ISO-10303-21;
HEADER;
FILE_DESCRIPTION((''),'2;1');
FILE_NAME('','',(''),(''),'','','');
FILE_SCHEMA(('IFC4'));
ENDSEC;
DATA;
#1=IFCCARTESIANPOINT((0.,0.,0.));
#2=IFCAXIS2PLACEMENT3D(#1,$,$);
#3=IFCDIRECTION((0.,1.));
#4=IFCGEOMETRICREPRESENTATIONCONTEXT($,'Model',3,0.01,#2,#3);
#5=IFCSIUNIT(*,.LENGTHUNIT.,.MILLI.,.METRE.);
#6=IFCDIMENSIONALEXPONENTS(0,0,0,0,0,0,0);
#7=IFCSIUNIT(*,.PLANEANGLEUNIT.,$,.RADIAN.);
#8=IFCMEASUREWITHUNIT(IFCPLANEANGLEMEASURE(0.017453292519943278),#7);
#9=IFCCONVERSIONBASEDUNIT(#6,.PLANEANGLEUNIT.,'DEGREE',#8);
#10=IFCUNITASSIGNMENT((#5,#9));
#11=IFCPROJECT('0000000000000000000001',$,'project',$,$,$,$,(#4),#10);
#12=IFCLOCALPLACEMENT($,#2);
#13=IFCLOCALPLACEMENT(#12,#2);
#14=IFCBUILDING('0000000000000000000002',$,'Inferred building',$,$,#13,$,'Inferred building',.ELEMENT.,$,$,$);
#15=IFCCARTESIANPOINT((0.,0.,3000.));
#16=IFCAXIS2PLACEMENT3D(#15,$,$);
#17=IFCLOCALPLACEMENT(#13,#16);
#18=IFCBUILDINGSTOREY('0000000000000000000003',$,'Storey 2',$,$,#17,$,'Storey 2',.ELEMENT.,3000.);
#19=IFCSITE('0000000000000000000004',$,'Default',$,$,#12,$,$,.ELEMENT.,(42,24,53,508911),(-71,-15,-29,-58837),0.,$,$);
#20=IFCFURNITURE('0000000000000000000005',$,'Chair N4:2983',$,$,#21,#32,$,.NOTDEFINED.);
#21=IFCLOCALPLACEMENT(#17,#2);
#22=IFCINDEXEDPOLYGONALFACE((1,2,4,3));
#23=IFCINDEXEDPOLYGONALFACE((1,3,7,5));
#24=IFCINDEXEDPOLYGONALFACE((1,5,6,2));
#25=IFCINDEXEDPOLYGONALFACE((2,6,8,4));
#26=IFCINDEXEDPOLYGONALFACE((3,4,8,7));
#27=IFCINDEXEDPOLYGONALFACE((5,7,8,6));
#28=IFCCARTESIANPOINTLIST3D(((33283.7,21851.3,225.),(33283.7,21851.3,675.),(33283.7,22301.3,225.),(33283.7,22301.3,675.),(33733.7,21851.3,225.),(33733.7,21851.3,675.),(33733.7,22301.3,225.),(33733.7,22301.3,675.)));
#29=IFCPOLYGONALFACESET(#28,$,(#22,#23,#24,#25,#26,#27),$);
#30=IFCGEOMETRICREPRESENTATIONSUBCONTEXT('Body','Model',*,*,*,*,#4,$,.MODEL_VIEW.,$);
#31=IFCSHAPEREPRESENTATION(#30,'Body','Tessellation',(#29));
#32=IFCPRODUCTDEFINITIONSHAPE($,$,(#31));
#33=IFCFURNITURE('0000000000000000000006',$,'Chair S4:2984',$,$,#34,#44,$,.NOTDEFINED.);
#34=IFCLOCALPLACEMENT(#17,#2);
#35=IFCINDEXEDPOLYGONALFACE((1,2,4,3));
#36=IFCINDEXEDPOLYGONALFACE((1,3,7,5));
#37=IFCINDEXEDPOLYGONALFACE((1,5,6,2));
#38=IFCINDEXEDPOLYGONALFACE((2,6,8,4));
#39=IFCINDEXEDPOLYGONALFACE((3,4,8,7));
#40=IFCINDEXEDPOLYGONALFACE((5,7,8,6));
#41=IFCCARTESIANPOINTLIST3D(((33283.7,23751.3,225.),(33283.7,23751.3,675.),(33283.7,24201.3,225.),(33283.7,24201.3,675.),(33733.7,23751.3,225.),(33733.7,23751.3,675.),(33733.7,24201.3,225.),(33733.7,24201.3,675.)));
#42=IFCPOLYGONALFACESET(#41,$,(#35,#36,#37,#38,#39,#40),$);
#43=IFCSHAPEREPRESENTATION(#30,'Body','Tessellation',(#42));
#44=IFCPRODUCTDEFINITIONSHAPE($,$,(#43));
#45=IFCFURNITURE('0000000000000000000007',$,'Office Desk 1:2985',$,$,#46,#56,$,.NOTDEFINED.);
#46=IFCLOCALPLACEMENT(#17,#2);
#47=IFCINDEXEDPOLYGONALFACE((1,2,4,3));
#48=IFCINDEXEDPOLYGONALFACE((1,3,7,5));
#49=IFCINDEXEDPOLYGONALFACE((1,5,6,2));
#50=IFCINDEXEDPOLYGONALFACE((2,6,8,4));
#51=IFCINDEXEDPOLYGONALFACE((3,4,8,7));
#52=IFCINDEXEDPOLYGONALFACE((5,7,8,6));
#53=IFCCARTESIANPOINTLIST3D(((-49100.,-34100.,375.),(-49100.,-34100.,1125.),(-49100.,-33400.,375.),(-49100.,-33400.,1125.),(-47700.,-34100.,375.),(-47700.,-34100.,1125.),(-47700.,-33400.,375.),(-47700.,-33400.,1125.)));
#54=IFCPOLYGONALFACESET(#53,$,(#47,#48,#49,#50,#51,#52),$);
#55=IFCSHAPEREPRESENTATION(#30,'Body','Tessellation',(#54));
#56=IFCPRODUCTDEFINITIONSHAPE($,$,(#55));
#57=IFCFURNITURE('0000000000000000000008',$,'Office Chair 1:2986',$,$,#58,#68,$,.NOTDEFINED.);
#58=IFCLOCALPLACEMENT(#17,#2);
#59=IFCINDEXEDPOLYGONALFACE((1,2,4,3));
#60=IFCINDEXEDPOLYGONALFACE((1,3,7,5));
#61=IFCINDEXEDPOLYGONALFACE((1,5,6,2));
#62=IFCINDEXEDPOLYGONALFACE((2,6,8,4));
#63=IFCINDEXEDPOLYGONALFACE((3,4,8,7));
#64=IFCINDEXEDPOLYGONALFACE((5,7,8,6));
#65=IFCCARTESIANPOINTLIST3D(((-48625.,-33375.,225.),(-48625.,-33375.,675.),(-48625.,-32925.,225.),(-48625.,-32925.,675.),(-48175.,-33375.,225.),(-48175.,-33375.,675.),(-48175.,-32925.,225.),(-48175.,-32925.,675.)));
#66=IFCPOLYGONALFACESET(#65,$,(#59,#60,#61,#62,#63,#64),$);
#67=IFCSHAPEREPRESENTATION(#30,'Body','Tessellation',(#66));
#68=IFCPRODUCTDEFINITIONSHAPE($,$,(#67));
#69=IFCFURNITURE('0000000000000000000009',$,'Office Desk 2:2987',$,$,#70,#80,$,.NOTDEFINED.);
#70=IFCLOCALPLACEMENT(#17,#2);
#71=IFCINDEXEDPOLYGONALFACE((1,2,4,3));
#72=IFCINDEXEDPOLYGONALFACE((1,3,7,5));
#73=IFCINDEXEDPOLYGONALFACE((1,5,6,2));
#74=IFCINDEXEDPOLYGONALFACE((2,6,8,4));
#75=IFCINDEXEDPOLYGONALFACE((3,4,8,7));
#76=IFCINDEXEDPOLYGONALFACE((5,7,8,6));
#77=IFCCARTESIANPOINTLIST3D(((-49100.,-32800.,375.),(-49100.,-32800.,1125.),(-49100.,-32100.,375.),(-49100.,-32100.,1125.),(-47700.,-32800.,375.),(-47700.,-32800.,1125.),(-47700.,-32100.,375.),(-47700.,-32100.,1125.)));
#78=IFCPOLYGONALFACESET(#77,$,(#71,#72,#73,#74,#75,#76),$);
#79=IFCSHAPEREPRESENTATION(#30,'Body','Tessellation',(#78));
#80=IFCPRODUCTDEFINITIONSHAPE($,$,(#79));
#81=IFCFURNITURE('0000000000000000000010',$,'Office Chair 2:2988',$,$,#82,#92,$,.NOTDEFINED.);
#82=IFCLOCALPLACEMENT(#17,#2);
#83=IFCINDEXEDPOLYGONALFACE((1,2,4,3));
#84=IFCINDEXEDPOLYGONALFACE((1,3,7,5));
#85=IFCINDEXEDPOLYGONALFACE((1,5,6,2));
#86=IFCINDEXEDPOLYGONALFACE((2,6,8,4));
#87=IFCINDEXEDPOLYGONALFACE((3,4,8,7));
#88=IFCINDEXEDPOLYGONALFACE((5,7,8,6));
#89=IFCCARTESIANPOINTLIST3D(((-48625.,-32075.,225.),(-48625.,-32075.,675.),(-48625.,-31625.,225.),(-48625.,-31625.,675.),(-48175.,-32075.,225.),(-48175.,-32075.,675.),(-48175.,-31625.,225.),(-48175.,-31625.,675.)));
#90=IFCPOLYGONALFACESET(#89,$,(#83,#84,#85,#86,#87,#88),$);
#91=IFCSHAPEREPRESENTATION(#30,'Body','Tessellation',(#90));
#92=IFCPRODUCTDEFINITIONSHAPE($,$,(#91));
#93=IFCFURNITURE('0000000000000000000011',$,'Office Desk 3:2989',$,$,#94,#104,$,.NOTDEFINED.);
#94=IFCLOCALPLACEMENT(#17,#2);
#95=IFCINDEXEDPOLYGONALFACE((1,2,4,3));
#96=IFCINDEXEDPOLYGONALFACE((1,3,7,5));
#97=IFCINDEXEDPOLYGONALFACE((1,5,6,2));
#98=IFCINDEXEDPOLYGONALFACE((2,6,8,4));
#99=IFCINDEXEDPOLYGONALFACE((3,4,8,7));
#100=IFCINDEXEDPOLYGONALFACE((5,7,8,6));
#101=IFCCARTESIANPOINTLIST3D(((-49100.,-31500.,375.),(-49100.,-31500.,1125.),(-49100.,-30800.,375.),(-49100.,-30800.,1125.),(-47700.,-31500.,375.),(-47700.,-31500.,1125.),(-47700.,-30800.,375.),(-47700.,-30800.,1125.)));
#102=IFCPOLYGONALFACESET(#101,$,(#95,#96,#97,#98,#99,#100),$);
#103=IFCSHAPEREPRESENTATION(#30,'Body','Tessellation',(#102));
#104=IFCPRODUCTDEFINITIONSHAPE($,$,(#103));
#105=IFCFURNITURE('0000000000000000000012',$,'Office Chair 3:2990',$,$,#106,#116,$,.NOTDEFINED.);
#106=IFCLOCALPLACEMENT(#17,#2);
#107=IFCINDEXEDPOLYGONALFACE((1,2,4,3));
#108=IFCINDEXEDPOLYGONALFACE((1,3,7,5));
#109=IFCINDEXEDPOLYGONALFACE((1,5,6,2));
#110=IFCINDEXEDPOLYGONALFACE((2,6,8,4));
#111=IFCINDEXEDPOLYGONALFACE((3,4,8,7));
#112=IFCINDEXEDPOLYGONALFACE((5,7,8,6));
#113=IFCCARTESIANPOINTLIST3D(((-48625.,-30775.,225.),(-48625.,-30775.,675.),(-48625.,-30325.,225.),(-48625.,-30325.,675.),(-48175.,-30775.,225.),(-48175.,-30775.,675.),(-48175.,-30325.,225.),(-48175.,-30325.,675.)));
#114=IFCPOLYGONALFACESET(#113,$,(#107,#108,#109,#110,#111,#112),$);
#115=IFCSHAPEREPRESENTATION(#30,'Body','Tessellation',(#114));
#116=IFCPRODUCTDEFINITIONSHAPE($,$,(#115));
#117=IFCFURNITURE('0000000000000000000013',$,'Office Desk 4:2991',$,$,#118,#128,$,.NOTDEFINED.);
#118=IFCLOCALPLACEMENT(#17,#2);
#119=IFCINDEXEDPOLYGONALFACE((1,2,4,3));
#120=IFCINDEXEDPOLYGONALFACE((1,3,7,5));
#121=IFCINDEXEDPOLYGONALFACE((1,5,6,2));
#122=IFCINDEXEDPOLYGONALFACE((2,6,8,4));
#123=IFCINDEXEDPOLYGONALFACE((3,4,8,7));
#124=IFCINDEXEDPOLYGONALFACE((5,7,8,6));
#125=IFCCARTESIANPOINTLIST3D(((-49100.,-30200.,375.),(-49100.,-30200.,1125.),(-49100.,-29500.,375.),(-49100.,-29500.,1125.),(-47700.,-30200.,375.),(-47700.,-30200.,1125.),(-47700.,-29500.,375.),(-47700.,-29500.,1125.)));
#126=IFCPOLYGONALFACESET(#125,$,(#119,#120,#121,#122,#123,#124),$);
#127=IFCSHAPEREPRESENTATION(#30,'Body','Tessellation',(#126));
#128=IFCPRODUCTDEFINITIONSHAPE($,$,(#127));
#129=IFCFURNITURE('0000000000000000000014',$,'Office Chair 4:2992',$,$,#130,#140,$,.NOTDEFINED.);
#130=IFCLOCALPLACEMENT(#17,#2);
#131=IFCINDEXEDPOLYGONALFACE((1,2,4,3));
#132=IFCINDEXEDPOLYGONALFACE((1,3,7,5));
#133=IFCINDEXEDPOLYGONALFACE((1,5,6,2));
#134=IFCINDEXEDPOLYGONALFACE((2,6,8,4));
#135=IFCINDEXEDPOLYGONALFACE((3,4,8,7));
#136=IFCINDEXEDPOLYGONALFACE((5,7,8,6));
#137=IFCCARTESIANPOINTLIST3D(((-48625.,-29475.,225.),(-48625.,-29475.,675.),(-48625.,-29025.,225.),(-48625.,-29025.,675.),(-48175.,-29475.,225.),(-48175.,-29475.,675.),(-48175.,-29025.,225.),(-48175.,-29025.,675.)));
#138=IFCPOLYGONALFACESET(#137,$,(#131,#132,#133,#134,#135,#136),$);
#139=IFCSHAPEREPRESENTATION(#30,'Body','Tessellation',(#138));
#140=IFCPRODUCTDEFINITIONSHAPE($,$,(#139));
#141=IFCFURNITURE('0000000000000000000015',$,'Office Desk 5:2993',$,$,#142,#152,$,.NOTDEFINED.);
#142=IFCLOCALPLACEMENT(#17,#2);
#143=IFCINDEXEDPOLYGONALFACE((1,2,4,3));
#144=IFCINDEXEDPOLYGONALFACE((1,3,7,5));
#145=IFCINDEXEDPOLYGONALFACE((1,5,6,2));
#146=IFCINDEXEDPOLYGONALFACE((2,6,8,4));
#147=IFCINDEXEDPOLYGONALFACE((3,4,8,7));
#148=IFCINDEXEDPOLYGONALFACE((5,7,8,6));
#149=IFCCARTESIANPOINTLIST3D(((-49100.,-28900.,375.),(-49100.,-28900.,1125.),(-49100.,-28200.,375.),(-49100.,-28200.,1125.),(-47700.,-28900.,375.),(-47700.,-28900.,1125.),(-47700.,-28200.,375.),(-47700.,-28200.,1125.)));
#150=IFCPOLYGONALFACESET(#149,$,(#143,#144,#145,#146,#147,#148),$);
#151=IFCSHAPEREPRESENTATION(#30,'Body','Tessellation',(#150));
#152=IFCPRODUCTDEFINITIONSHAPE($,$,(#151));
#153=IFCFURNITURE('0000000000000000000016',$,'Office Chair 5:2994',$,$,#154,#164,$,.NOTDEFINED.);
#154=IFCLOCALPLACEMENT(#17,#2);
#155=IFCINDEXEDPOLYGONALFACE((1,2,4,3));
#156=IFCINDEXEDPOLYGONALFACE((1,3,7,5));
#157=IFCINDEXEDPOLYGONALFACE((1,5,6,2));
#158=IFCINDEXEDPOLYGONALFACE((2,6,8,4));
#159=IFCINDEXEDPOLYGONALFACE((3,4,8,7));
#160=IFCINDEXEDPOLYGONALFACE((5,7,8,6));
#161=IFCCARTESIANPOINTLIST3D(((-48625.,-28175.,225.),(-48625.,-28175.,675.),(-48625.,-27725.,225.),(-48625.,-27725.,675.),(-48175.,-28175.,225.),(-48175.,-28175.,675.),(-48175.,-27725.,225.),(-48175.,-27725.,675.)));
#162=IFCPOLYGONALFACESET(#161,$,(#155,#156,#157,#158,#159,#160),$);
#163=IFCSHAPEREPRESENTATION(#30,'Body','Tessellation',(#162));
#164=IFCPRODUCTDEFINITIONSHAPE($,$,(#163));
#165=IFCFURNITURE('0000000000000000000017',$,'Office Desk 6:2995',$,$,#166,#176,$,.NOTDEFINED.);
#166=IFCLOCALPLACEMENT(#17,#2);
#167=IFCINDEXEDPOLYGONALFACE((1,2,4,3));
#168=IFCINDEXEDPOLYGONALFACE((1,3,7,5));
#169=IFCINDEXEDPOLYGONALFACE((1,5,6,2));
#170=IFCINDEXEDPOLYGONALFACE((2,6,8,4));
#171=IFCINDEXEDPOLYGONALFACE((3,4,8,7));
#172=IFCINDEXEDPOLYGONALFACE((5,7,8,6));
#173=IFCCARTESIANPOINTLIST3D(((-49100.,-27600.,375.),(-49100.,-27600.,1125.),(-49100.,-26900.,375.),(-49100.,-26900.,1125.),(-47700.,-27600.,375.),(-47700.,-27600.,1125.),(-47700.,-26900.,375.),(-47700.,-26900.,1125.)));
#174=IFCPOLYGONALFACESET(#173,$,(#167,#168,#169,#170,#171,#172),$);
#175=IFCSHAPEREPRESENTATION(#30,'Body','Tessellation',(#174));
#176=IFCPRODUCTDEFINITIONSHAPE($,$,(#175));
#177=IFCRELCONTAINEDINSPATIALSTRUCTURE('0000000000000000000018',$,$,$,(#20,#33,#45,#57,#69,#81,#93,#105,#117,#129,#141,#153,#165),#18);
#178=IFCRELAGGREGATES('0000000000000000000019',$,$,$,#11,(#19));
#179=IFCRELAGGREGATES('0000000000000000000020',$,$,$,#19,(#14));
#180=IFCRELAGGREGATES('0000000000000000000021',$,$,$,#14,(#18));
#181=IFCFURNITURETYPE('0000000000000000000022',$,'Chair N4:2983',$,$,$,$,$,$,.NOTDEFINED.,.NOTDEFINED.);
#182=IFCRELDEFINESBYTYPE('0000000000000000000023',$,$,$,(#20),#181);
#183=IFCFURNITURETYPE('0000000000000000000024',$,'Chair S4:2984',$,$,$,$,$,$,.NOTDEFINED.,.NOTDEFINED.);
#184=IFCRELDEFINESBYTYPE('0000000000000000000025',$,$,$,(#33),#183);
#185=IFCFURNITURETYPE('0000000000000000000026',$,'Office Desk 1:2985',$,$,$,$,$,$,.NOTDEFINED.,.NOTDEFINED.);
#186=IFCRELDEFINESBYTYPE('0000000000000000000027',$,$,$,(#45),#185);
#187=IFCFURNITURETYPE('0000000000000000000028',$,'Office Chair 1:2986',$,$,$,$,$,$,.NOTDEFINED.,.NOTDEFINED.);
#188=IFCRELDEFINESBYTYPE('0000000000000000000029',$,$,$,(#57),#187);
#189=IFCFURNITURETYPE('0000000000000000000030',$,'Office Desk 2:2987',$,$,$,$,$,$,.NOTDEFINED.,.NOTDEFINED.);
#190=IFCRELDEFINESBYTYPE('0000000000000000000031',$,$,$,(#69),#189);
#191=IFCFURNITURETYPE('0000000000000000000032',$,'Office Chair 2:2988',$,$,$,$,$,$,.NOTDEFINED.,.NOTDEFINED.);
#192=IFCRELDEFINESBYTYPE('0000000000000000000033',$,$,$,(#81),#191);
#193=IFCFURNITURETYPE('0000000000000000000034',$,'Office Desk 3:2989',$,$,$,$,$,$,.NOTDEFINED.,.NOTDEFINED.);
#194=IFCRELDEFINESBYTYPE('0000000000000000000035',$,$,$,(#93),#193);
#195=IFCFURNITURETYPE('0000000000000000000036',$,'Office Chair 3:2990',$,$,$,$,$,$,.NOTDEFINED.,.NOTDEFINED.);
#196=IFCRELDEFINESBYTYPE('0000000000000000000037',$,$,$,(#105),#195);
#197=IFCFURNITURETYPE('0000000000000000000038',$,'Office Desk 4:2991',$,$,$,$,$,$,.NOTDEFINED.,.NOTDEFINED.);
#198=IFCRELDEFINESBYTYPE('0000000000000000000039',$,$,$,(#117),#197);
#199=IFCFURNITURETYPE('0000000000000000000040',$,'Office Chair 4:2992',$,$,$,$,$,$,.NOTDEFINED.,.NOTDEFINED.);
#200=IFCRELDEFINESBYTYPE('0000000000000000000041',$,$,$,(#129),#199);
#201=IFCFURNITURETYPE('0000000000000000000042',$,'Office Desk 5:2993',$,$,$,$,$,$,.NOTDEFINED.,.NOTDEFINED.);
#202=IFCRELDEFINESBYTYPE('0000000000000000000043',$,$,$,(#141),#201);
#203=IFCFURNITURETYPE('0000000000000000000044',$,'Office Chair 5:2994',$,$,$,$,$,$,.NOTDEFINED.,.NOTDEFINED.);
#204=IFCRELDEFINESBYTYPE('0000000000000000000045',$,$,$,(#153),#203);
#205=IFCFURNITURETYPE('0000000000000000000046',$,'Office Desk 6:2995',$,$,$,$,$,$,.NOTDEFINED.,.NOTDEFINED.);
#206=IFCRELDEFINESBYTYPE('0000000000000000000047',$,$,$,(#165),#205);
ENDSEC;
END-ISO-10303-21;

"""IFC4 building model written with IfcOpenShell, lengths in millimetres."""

from ifc_helpers import new_model, entity, si_unit, converted_unit, direction, frame, origin, origin_2d_with_axis, place, context, subcontext, project, spatial, rectangle, extrude, type_object, element, save


model = new_model("IFC4")

# Units and contexts
model_context = context("Model", 3, precision=0.01, world=origin(), true_north=direction((0.0, 1.0)))
body_context = subcontext(model_context, "Body", "Model", "MODEL_VIEW")
ifc_project = project(units=[si_unit("LENGTHUNIT", "METRE", prefix="MILLI"), converted_unit("PLANEANGLEUNIT", "DEGREE", entity("IfcPlaneAngleMeasure", 0.017453292519943278), si_unit("PLANEANGLEUNIT", "RADIAN"), dimensions=[0, 0, 0, 0, 0, 0, 0])], contexts=[model_context])

# Site, building, storey
site_placement = place(None, origin())
site = spatial("IfcSite", under=ifc_project, at=site_placement, Name="Default", CompositionType="ELEMENT", RefLatitude=(42, 24, 53, 508911), RefLongitude=(-71, -15, -29, -58837), RefElevation=0.0)
building_placement = place(site_placement, origin())
building = spatial("IfcBuilding", under=site, at=building_placement, Name="Inferred building", LongName="Inferred building", CompositionType="ELEMENT")
storey_placement = place(building_placement, frame((0.0, 0.0, 3000.0)))
storey = spatial("IfcBuildingStorey", under=building, at=storey_placement, Name="Storey 2", LongName="Storey 2", CompositionType="ELEMENT", Elevation=3000.0)

# Furniture
furniture_type_1 = type_object("IfcFurnitureType", Name="Chair N4:2983", PredefinedType="NOTDEFINED")
furniture_1_placement = place(storey_placement, origin())
element("IfcFurniture", 1, at=furniture_1_placement, inside=storey, type_object=furniture_type_1, Name="Chair N4:2983", PredefinedType="NOTDEFINED", context=body_context, shape_type="SweptSolid", body=[
    extrude(rectangle(XDim=450.0, YDim=450.0, at=origin_2d_with_axis()), frame((33508.7, 22076.3, 225.0)), (0.0, 0.0, 1.0), 450.0),
])
furniture_type_2 = type_object("IfcFurnitureType", Name="Chair S4:2984", PredefinedType="NOTDEFINED")
furniture_2_placement = place(storey_placement, origin())
element("IfcFurniture", 2, at=furniture_2_placement, inside=storey, type_object=furniture_type_2, Name="Chair S4:2984", PredefinedType="NOTDEFINED", context=body_context, shape_type="SweptSolid", body=[
    extrude(rectangle(XDim=450.0, YDim=450.0, at=origin_2d_with_axis()), frame((33508.7, 23976.3, 225.0)), (0.0, 0.0, 1.0), 450.0),
])
furniture_type_3 = type_object("IfcFurnitureType", Name="Office Desk 1:2985", PredefinedType="NOTDEFINED")
furniture_3_placement = place(storey_placement, origin())
element("IfcFurniture", 3, at=furniture_3_placement, inside=storey, type_object=furniture_type_3, Name="Office Desk 1:2985", PredefinedType="NOTDEFINED", context=body_context, shape_type="SweptSolid", body=[
    extrude(rectangle(XDim=1400.0, YDim=700.0, at=origin_2d_with_axis()), frame((-48400.0, -33750.0, 375.0)), (0.0, 0.0, 1.0), 750.0),
])
furniture_type_4 = type_object("IfcFurnitureType", Name="Office Chair 1:2986", PredefinedType="NOTDEFINED")
furniture_4_placement = place(storey_placement, origin())
element("IfcFurniture", 4, at=furniture_4_placement, inside=storey, type_object=furniture_type_4, Name="Office Chair 1:2986", PredefinedType="NOTDEFINED", context=body_context, shape_type="SweptSolid", body=[
    extrude(rectangle(XDim=450.0, YDim=450.0, at=origin_2d_with_axis()), frame((-48400.0, -33150.0, 225.0)), (0.0, 0.0, 1.0), 450.0),
])
furniture_type_5 = type_object("IfcFurnitureType", Name="Office Desk 2:2987", PredefinedType="NOTDEFINED")
furniture_5_placement = place(storey_placement, origin())
element("IfcFurniture", 5, at=furniture_5_placement, inside=storey, type_object=furniture_type_5, Name="Office Desk 2:2987", PredefinedType="NOTDEFINED", context=body_context, shape_type="SweptSolid", body=[
    extrude(rectangle(XDim=1400.0, YDim=700.0, at=origin_2d_with_axis()), frame((-48400.0, -32450.0, 375.0)), (0.0, 0.0, 1.0), 750.0),
])
furniture_type_6 = type_object("IfcFurnitureType", Name="Office Chair 2:2988", PredefinedType="NOTDEFINED")
furniture_6_placement = place(storey_placement, origin())
element("IfcFurniture", 6, at=furniture_6_placement, inside=storey, type_object=furniture_type_6, Name="Office Chair 2:2988", PredefinedType="NOTDEFINED", context=body_context, shape_type="SweptSolid", body=[
    extrude(rectangle(XDim=450.0, YDim=450.0, at=origin_2d_with_axis()), frame((-48400.0, -31850.0, 225.0)), (0.0, 0.0, 1.0), 450.0),
])
furniture_type_7 = type_object("IfcFurnitureType", Name="Office Desk 3:2989", PredefinedType="NOTDEFINED")
furniture_7_placement = place(storey_placement, origin())
element("IfcFurniture", 7, at=furniture_7_placement, inside=storey, type_object=furniture_type_7, Name="Office Desk 3:2989", PredefinedType="NOTDEFINED", context=body_context, shape_type="SweptSolid", body=[
    extrude(rectangle(XDim=1400.0, YDim=700.0, at=origin_2d_with_axis()), frame((-48400.0, -31150.0, 375.0)), (0.0, 0.0, 1.0), 750.0),
])
furniture_type_8 = type_object("IfcFurnitureType", Name="Office Chair 3:2990", PredefinedType="NOTDEFINED")
furniture_8_placement = place(storey_placement, origin())
element("IfcFurniture", 8, at=furniture_8_placement, inside=storey, type_object=furniture_type_8, Name="Office Chair 3:2990", PredefinedType="NOTDEFINED", context=body_context, shape_type="SweptSolid", body=[
    extrude(rectangle(XDim=450.0, YDim=450.0, at=origin_2d_with_axis()), frame((-48400.0, -30550.0, 225.0)), (0.0, 0.0, 1.0), 450.0),
])
furniture_type_9 = type_object("IfcFurnitureType", Name="Office Desk 4:2991", PredefinedType="NOTDEFINED")
furniture_9_placement = place(storey_placement, origin())
element("IfcFurniture", 9, at=furniture_9_placement, inside=storey, type_object=furniture_type_9, Name="Office Desk 4:2991", PredefinedType="NOTDEFINED", context=body_context, shape_type="SweptSolid", body=[
    extrude(rectangle(XDim=1400.0, YDim=700.0, at=origin_2d_with_axis()), frame((-48400.0, -29850.0, 375.0)), (0.0, 0.0, 1.0), 750.0),
])
furniture_type_10 = type_object("IfcFurnitureType", Name="Office Chair 4:2992", PredefinedType="NOTDEFINED")
furniture_10_placement = place(storey_placement, origin())
element("IfcFurniture", 10, at=furniture_10_placement, inside=storey, type_object=furniture_type_10, Name="Office Chair 4:2992", PredefinedType="NOTDEFINED", context=body_context, shape_type="SweptSolid", body=[
    extrude(rectangle(XDim=450.0, YDim=450.0, at=origin_2d_with_axis()), frame((-48400.0, -29250.0, 225.0)), (0.0, 0.0, 1.0), 450.0),
])
furniture_type_11 = type_object("IfcFurnitureType", Name="Office Desk 5:2993", PredefinedType="NOTDEFINED")
furniture_11_placement = place(storey_placement, origin())
element("IfcFurniture", 11, at=furniture_11_placement, inside=storey, type_object=furniture_type_11, Name="Office Desk 5:2993", PredefinedType="NOTDEFINED", context=body_context, shape_type="SweptSolid", body=[
    extrude(rectangle(XDim=1400.0, YDim=700.0, at=origin_2d_with_axis()), frame((-48400.0, -28550.0, 375.0)), (0.0, 0.0, 1.0), 750.0),
])
furniture_type_12 = type_object("IfcFurnitureType", Name="Office Chair 5:2994", PredefinedType="NOTDEFINED")
furniture_12_placement = place(storey_placement, origin())
element("IfcFurniture", 12, at=furniture_12_placement, inside=storey, type_object=furniture_type_12, Name="Office Chair 5:2994", PredefinedType="NOTDEFINED", context=body_context, shape_type="SweptSolid", body=[
    extrude(rectangle(XDim=450.0, YDim=450.0, at=origin_2d_with_axis()), frame((-48400.0, -27950.0, 225.0)), (0.0, 0.0, 1.0), 450.0),
])
furniture_type_13 = type_object("IfcFurnitureType", Name="Office Desk 6:2995", PredefinedType="NOTDEFINED")
furniture_13_placement = place(storey_placement, origin())
element("IfcFurniture", 13, at=furniture_13_placement, inside=storey, type_object=furniture_type_13, Name="Office Desk 6:2995", PredefinedType="NOTDEFINED", context=body_context, shape_type="SweptSolid", body=[
    extrude(rectangle(XDim=1400.0, YDim=700.0, at=origin_2d_with_axis()), frame((-48400.0, -27250.0, 375.0)), (0.0, 0.0, 1.0), 750.0),
])

save(model, "model.ifc")
